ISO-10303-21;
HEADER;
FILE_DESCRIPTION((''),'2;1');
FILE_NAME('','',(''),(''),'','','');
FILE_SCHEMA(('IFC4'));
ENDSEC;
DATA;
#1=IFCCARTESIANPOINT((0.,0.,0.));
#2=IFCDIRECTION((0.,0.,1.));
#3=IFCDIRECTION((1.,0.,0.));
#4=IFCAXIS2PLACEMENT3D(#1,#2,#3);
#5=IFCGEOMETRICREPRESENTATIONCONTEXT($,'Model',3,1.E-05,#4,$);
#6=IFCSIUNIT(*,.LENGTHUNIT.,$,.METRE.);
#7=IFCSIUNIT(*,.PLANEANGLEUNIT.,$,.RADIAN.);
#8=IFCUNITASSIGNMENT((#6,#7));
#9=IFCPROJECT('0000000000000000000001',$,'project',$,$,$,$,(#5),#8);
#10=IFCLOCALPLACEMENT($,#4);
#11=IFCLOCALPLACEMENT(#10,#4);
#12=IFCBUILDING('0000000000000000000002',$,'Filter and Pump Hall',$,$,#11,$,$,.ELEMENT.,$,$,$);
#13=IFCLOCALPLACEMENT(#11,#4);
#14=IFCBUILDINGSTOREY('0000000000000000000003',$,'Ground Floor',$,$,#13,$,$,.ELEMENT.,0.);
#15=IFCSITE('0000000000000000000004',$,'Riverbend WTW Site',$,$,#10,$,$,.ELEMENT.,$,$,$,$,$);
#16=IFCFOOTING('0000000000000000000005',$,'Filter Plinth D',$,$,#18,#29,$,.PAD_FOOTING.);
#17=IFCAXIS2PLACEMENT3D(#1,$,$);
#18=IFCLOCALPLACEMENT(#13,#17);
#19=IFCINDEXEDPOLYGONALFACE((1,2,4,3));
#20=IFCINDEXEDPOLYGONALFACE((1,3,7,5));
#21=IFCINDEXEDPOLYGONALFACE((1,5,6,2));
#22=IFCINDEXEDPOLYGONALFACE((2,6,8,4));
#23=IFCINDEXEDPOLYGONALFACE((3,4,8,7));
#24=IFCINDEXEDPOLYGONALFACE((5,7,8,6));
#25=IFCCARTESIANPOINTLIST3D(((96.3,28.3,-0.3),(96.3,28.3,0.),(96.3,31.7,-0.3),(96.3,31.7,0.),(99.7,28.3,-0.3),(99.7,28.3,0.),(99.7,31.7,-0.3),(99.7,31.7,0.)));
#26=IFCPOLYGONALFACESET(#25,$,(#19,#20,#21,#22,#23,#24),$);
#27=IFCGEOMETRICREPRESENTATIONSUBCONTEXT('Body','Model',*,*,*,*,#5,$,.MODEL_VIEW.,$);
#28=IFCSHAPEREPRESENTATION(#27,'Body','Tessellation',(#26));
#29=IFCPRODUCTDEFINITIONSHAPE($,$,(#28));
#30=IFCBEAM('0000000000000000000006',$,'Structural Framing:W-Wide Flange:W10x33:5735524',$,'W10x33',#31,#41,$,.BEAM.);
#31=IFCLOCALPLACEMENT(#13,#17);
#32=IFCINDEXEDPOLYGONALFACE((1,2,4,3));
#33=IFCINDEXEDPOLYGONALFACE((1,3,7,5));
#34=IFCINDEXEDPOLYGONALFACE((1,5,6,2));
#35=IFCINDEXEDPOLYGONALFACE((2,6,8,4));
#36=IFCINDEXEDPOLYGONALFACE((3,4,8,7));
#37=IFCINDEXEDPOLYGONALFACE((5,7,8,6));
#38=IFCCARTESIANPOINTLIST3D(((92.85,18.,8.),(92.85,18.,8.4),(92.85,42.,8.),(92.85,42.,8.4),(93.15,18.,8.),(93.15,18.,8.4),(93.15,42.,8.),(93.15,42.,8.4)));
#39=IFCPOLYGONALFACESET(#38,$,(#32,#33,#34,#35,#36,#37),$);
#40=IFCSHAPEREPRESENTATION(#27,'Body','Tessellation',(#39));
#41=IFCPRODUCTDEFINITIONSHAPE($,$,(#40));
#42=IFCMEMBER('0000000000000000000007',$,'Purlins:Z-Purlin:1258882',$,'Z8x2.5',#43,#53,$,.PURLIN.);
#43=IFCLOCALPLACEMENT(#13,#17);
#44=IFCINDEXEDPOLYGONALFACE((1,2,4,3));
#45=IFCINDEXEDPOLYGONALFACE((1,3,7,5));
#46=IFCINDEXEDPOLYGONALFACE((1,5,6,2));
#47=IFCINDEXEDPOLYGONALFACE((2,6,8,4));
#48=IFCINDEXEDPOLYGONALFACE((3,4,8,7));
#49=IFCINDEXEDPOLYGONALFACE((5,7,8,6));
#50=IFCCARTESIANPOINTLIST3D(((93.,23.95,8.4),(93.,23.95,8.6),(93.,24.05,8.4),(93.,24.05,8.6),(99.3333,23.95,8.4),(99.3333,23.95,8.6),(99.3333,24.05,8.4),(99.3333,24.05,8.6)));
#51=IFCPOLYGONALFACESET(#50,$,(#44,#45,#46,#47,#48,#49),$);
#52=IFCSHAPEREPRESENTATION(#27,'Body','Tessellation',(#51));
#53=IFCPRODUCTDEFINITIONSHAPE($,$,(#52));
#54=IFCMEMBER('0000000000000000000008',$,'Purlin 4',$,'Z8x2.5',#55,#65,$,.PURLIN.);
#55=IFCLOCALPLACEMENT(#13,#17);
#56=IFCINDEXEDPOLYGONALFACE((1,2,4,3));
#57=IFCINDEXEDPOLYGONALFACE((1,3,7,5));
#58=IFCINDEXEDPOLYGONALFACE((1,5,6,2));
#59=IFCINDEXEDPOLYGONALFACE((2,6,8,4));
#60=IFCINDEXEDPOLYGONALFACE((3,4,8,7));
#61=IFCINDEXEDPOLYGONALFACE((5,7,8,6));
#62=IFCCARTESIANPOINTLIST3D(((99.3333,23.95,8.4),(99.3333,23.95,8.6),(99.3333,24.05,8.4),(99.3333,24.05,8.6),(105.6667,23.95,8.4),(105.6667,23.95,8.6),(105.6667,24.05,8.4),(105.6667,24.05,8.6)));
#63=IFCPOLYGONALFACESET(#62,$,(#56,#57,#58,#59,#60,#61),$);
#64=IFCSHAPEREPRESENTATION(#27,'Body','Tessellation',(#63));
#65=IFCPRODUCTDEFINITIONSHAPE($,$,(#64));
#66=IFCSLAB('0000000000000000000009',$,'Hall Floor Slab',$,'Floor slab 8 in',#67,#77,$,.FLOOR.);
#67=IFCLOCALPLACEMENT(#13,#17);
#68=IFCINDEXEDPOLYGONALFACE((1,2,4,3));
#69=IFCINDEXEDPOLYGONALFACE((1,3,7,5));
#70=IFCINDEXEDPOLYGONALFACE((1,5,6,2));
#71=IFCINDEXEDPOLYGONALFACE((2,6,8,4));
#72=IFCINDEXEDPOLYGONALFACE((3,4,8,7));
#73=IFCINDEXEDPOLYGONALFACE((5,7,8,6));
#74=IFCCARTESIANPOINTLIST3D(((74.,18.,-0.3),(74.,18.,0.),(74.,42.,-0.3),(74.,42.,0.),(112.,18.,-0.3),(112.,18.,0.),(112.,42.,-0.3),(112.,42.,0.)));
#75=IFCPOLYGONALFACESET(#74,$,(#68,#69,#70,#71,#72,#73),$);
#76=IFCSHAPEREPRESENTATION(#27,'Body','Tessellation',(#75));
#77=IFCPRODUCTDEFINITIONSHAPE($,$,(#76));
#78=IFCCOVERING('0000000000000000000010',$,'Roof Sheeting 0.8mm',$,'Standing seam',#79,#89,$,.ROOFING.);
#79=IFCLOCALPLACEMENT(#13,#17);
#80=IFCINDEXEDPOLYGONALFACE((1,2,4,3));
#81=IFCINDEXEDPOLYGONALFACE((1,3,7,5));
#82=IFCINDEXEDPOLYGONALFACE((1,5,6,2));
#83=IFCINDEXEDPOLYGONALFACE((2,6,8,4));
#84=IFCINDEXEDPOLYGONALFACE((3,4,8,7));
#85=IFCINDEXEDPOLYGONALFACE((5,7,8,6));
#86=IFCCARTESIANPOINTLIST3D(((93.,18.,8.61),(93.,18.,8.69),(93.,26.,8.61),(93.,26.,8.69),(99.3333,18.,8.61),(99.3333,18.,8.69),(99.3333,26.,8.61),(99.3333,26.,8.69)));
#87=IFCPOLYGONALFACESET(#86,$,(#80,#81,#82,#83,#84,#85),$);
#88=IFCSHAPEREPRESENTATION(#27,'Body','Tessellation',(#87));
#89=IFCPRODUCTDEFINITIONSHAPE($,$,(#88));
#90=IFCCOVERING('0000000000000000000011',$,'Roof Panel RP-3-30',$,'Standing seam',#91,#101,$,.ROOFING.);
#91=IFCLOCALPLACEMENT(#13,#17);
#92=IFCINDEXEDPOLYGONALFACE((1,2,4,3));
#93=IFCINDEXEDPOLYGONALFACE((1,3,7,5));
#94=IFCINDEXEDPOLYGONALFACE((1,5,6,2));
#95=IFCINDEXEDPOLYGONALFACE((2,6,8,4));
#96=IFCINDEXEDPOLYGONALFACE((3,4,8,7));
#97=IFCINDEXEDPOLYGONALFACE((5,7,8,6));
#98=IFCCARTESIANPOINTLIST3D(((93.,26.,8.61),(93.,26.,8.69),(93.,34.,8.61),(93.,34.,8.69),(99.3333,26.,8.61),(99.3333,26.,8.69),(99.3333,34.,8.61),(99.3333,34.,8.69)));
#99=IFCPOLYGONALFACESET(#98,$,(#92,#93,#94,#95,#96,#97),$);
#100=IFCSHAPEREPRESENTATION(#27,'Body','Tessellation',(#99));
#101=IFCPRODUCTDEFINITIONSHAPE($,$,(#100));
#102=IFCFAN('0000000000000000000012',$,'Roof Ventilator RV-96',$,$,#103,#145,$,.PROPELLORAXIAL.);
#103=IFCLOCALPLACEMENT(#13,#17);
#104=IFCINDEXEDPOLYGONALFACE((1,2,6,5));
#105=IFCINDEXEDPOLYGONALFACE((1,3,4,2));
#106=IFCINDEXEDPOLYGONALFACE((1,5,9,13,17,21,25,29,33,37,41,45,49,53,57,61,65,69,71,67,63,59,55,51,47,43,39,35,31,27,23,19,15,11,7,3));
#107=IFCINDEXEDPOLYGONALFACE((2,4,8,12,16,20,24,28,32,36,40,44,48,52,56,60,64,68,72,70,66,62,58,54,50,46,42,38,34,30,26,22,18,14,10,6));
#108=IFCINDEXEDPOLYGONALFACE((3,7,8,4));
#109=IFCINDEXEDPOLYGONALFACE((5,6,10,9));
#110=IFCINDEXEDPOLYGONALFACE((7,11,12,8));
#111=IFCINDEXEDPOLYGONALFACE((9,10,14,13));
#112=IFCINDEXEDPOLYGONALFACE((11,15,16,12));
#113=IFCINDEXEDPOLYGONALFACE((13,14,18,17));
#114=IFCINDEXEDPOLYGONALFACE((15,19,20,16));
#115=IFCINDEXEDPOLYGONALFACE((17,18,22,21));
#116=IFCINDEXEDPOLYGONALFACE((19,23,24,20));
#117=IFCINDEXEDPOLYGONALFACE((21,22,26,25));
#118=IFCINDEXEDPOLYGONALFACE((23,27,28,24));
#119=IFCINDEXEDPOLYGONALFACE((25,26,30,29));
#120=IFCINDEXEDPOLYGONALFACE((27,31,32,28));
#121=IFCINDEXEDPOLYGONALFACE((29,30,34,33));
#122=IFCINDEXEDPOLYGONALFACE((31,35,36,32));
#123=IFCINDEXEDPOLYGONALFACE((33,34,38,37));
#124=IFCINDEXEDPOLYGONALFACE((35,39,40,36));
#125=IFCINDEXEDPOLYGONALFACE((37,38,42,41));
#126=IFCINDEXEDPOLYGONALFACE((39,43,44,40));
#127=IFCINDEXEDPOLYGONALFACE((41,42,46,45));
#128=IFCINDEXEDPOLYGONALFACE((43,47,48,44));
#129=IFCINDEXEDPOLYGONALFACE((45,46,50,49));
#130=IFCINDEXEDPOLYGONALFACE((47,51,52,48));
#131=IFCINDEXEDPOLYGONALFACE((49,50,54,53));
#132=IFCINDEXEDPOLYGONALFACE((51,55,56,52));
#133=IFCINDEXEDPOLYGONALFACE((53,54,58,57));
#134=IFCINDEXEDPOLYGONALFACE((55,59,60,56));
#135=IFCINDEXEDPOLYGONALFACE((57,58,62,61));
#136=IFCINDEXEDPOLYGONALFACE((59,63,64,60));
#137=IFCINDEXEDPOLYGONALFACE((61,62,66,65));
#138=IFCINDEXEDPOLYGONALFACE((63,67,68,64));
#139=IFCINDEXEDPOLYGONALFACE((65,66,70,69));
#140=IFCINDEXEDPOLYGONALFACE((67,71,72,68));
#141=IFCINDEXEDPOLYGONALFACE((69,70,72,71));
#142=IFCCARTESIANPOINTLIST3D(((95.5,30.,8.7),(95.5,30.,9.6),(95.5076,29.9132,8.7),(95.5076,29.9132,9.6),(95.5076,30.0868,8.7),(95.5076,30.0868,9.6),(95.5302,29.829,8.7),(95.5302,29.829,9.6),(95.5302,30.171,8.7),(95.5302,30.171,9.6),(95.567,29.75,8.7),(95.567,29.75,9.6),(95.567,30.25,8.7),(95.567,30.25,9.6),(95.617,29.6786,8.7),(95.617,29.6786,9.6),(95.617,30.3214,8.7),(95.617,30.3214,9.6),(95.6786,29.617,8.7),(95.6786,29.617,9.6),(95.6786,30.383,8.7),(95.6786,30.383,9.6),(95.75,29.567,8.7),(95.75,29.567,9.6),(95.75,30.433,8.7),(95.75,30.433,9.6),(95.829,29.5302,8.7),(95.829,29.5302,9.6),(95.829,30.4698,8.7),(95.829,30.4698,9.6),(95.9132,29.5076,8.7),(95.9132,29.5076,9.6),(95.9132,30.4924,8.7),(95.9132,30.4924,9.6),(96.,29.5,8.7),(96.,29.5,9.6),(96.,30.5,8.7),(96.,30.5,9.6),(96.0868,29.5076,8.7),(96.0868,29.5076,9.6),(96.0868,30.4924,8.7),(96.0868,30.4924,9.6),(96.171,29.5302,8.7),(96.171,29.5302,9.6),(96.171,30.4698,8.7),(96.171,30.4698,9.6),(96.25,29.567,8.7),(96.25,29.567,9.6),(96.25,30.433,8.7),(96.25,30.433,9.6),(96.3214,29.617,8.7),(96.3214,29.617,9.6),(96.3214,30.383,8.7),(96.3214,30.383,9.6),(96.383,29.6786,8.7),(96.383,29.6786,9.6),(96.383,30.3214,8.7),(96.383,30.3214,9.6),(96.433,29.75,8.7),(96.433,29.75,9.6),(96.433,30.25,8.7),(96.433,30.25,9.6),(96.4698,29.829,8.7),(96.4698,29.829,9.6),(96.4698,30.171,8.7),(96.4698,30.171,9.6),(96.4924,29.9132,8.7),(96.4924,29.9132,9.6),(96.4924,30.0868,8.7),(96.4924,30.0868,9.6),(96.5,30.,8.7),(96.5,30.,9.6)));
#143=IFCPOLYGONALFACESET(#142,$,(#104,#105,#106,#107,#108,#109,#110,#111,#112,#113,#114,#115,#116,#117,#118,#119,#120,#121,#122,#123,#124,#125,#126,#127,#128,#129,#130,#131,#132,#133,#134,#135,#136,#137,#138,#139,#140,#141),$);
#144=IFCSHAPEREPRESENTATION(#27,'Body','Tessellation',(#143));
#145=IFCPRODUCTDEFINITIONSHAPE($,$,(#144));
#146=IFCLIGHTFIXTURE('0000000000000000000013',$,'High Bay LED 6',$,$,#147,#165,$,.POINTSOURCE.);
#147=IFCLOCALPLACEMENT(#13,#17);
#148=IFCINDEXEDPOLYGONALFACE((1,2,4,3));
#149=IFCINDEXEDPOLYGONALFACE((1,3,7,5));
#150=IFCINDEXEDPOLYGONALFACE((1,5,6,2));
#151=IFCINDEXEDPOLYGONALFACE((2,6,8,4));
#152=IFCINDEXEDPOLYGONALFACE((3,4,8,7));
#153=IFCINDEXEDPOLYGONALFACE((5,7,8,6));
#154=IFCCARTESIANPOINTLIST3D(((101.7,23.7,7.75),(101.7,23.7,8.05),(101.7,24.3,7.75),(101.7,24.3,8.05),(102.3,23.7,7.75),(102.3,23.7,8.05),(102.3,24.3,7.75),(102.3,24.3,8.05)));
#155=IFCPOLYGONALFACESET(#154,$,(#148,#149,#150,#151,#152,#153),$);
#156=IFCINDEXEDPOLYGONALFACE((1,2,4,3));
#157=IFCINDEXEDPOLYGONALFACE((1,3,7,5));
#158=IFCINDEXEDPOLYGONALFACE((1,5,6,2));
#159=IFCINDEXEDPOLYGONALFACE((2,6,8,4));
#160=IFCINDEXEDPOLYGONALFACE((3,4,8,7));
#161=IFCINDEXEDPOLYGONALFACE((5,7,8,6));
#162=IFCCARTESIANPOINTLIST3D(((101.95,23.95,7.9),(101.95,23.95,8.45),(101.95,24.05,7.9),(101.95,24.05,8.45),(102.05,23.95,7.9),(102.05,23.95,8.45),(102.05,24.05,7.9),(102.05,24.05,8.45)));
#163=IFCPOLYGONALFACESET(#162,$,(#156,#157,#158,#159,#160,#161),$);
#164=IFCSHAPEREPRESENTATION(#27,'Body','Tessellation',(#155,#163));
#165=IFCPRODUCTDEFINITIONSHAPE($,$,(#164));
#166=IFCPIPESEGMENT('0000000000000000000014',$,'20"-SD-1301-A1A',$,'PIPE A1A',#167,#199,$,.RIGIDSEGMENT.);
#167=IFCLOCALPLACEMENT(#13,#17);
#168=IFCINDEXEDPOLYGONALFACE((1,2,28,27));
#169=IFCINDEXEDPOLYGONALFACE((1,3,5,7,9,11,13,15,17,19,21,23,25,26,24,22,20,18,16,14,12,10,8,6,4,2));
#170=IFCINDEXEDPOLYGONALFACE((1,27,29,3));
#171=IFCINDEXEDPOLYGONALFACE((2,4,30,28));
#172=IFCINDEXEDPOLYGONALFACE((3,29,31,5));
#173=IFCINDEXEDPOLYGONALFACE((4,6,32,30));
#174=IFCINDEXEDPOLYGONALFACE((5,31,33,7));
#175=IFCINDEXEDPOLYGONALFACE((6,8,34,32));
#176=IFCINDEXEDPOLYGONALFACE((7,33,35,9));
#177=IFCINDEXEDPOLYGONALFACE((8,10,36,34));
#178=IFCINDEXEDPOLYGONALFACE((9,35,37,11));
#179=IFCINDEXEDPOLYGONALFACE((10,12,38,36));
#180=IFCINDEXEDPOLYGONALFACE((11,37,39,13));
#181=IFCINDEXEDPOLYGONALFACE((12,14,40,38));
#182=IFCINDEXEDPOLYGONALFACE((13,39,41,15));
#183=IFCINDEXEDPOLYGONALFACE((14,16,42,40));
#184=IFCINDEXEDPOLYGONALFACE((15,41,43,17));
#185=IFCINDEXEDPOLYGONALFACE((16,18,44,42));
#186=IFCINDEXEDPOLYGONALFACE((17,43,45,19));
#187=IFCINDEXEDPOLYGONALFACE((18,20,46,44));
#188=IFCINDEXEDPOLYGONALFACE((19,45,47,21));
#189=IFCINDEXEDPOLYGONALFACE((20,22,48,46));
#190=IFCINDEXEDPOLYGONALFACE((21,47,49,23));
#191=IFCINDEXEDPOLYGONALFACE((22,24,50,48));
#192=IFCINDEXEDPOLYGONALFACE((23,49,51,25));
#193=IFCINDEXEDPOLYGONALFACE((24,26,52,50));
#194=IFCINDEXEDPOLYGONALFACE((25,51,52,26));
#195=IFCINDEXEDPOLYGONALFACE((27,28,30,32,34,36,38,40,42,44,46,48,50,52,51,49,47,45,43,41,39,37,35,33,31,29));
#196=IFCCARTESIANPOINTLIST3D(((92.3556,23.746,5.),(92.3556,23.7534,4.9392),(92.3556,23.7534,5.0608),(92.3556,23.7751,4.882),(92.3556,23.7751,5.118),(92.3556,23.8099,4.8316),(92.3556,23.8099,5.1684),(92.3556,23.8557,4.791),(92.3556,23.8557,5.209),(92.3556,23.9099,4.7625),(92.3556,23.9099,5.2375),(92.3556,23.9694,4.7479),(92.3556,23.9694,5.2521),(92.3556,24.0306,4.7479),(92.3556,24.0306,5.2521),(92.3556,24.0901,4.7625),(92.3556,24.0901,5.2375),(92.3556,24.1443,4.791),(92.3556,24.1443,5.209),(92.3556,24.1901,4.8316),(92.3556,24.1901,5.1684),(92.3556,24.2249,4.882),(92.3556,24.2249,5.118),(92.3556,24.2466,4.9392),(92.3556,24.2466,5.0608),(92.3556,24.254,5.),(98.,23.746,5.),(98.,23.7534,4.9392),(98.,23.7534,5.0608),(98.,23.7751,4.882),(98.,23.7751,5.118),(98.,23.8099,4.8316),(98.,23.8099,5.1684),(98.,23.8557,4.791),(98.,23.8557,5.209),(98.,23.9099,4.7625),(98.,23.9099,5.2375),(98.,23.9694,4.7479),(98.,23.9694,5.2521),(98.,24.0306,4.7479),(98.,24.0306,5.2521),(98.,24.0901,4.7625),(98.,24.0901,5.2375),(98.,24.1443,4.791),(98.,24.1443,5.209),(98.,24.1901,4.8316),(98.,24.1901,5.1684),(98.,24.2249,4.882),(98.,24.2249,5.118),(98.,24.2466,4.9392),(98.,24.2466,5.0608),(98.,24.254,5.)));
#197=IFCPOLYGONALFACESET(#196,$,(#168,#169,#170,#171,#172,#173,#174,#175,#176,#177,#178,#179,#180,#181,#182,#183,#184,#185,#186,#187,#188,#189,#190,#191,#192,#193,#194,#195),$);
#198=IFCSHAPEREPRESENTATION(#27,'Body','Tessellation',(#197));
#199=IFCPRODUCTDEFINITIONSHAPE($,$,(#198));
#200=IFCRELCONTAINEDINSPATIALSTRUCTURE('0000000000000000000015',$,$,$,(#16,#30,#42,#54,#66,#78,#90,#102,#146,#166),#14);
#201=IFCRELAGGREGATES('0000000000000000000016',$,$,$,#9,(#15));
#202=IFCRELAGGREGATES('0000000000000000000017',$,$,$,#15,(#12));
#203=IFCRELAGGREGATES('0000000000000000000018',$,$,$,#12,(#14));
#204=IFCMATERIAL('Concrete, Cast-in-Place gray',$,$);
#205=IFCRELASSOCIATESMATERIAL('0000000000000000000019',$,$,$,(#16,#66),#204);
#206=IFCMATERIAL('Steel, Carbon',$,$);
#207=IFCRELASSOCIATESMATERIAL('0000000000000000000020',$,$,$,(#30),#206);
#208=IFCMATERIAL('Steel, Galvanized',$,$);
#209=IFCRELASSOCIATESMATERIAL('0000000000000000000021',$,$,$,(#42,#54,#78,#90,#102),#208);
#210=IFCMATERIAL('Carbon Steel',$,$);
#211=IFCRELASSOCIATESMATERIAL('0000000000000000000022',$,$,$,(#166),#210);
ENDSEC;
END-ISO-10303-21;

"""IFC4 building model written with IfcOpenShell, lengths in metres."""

from ifc_helpers import new_model, si_unit, frame, origin_with_axes, origin_2d, place, context, subcontext, project, spatial, rectangle, circle, extrude, material, element, save


model = new_model("IFC4")

# Units and contexts
model_context = context("Model", 3, precision=1e-05, world=origin_with_axes())
body_context = subcontext(model_context, "Body", "Model", "MODEL_VIEW")
ifc_project = project(units=[si_unit("LENGTHUNIT", "METRE"), si_unit("PLANEANGLEUNIT", "RADIAN")], contexts=[model_context])

# Site, building, storey
site_placement = place(None, origin_with_axes())
site = spatial("IfcSite", under=ifc_project, at=site_placement, Name="Riverbend WTW Site", CompositionType="ELEMENT")
building_placement = place(site_placement, origin_with_axes())
building = spatial("IfcBuilding", under=site, at=building_placement, Name="Filter and Pump Hall", CompositionType="ELEMENT")
storey_placement = place(building_placement, origin_with_axes())
storey = spatial("IfcBuildingStorey", under=building, at=storey_placement, Name="Ground Floor", CompositionType="ELEMENT", Elevation=0.0)

# Footing
ifc_material_1 = material(Name="Concrete, Cast-in-Place gray")
footing_placement = place(None, frame((98.0, 30.0, -0.15), z_axis=(0.0, 0.0, 1.0), x_axis=(1.0, 0.0, 0.0)))
element("IfcFooting", 1, at=footing_placement, inside=storey, material=ifc_material_1, Name="Filter Plinth D", PredefinedType="PAD_FOOTING", context=body_context, shape_type="SweptSolid", body=[
    extrude(rectangle(XDim=3.4, YDim=3.4, at=origin_2d()), frame((0.0, 0.0, -0.15), z_axis=(0.0, 0.0, 1.0), x_axis=(1.0, 0.0, 0.0)), (0.0, 0.0, 1.0), 0.3),
])

# Beam
ifc_material_2 = material(Name="Steel, Carbon")
beam_placement = place(None, frame((93.0, 30.0, 8.2), z_axis=(0.0, 0.0, 1.0), x_axis=(1.0, 0.0, 0.0)))
element("IfcBeam", 2, at=beam_placement, inside=storey, material=ifc_material_2, Name="Structural Framing:W-Wide Flange:W10x33:5735524", ObjectType="W10x33", PredefinedType="BEAM", context=body_context, shape_type="SweptSolid", body=[
    extrude(rectangle(XDim=0.3, YDim=24.0, at=origin_2d()), frame((0.0, 0.0, -0.2), z_axis=(0.0, 0.0, 1.0), x_axis=(1.0, 0.0, 0.0)), (0.0, 0.0, 1.0), 0.4),
])

# Members
ifc_material_3 = material(Name="Steel, Galvanized")
member_1_placement = place(None, frame((96.1667, 24.0, 8.5), z_axis=(0.0, 0.0, 1.0), x_axis=(1.0, 0.0, 0.0)))
element("IfcMember", 3, at=member_1_placement, inside=storey, material=ifc_material_3, Name="Purlins:Z-Purlin:1258882", ObjectType="Z8x2.5", PredefinedType="PURLIN", context=body_context, shape_type="SweptSolid", body=[
    extrude(rectangle(XDim=6.3333, YDim=0.1, at=origin_2d()), frame((0.0, 0.0, -0.1), z_axis=(0.0, 0.0, 1.0), x_axis=(1.0, 0.0, 0.0)), (0.0, 0.0, 1.0), 0.2),
])
member_2_placement = place(None, frame((102.5, 24.0, 8.5), z_axis=(0.0, 0.0, 1.0), x_axis=(1.0, 0.0, 0.0)))
element("IfcMember", 4, at=member_2_placement, inside=storey, material=ifc_material_3, Name="Purlin 4", ObjectType="Z8x2.5", PredefinedType="PURLIN", context=body_context, shape_type="SweptSolid", body=[
    extrude(rectangle(XDim=6.3333, YDim=0.1, at=origin_2d()), frame((0.0, 0.0, -0.1), z_axis=(0.0, 0.0, 1.0), x_axis=(1.0, 0.0, 0.0)), (0.0, 0.0, 1.0), 0.2),
])

# Slab
slab_placement = place(None, frame((93.0, 30.0, -0.15), z_axis=(0.0, 0.0, 1.0), x_axis=(1.0, 0.0, 0.0)))
element("IfcSlab", 5, at=slab_placement, inside=storey, material=ifc_material_1, Name="Hall Floor Slab", ObjectType="Floor slab 8 in", PredefinedType="FLOOR", context=body_context, shape_type="SweptSolid", body=[
    extrude(rectangle(XDim=38.0, YDim=24.0, at=origin_2d()), frame((0.0, 0.0, -0.15), z_axis=(0.0, 0.0, 1.0), x_axis=(1.0, 0.0, 0.0)), (0.0, 0.0, 1.0), 0.3),
])

# Coverings
for number, where, z_axis, x_axis, name in (
    (6, (96.1667, 22.0, 8.65), (0.0, 0.0, 1.0), (1.0, 0.0, 0.0), "Roof Sheeting 0.8mm"),
    (7, (96.1667, 30.0, 8.65), (0.0, 0.0, 1.0), (1.0, 0.0, 0.0), "Roof Panel RP-3-30"),
):
    element("IfcCovering", number, at=place(None, frame(where, z_axis=z_axis, x_axis=x_axis)), inside=storey, material=ifc_material_3, Name=name, ObjectType="Standing seam", PredefinedType="ROOFING", context=body_context, shape_type="SweptSolid", body=[
        extrude(rectangle(XDim=6.3333, YDim=8.0, at=origin_2d()), frame((0.0, 0.0, -0.04), z_axis=(0.0, 0.0, 1.0), x_axis=(1.0, 0.0, 0.0)), (0.0, 0.0, 1.0), 0.08),
    ])

# Fan
fan_placement = place(None, frame((96.0, 30.0, 8.7), z_axis=(0.0, 0.0, 1.0), x_axis=(1.0, 0.0, 0.0)))
element("IfcFan", 8, at=fan_placement, inside=storey, material=ifc_material_3, Name="Roof Ventilator RV-96", PredefinedType="PROPELLORAXIAL", context=body_context, shape_type="SweptSolid", body=[
    extrude(circle(Radius=0.5, at=origin_2d()), origin_with_axes(), (0.0, 0.0, 1.0), 0.9),
])

# Light fixture
light_fixture_placement = place(None, frame((102.0, 24.0, 7.9), z_axis=(0.0, 0.0, 1.0), x_axis=(1.0, 0.0, 0.0)))
element("IfcLightFixture", 9, at=light_fixture_placement, inside=storey, Name="High Bay LED 6", PredefinedType="POINTSOURCE", context=body_context, shape_type="SweptSolid", body=[
    extrude(rectangle(XDim=0.6, YDim=0.6, at=origin_2d()), frame((0.0, 0.0, -0.15), z_axis=(0.0, 0.0, 1.0), x_axis=(1.0, 0.0, 0.0)), (0.0, 0.0, 1.0), 0.3),
    extrude(rectangle(XDim=0.1, YDim=0.1, at=origin_2d()), origin_with_axes(), (0.0, 0.0, 1.0), 0.55),
])

# Pipe segment
ifc_material_4 = material(Name="Carbon Steel")
pipe_segment_1_placement = place(None, frame((92.3556, 24.0, 5.0), z_axis=(0.0, 0.0, 1.0), x_axis=(1.0, 0.0, 0.0)))
element("IfcPipeSegment", 10, at=pipe_segment_1_placement, inside=storey, material=ifc_material_4, Name="20\"-SD-1301-A1A", ObjectType="PIPE A1A", PredefinedType="RIGIDSEGMENT", context=body_context, shape_type="SweptSolid", body=[
    extrude(circle(Radius=0.254, at=origin_2d()), frame((0.0, 0.0, 0.0), z_axis=(1.0, 0.0, 0.0), x_axis=(0.0, 1.0, 0.0)), (0.0, 0.0, 1.0), 5.6444),
])

save(model, "model.ifc")
